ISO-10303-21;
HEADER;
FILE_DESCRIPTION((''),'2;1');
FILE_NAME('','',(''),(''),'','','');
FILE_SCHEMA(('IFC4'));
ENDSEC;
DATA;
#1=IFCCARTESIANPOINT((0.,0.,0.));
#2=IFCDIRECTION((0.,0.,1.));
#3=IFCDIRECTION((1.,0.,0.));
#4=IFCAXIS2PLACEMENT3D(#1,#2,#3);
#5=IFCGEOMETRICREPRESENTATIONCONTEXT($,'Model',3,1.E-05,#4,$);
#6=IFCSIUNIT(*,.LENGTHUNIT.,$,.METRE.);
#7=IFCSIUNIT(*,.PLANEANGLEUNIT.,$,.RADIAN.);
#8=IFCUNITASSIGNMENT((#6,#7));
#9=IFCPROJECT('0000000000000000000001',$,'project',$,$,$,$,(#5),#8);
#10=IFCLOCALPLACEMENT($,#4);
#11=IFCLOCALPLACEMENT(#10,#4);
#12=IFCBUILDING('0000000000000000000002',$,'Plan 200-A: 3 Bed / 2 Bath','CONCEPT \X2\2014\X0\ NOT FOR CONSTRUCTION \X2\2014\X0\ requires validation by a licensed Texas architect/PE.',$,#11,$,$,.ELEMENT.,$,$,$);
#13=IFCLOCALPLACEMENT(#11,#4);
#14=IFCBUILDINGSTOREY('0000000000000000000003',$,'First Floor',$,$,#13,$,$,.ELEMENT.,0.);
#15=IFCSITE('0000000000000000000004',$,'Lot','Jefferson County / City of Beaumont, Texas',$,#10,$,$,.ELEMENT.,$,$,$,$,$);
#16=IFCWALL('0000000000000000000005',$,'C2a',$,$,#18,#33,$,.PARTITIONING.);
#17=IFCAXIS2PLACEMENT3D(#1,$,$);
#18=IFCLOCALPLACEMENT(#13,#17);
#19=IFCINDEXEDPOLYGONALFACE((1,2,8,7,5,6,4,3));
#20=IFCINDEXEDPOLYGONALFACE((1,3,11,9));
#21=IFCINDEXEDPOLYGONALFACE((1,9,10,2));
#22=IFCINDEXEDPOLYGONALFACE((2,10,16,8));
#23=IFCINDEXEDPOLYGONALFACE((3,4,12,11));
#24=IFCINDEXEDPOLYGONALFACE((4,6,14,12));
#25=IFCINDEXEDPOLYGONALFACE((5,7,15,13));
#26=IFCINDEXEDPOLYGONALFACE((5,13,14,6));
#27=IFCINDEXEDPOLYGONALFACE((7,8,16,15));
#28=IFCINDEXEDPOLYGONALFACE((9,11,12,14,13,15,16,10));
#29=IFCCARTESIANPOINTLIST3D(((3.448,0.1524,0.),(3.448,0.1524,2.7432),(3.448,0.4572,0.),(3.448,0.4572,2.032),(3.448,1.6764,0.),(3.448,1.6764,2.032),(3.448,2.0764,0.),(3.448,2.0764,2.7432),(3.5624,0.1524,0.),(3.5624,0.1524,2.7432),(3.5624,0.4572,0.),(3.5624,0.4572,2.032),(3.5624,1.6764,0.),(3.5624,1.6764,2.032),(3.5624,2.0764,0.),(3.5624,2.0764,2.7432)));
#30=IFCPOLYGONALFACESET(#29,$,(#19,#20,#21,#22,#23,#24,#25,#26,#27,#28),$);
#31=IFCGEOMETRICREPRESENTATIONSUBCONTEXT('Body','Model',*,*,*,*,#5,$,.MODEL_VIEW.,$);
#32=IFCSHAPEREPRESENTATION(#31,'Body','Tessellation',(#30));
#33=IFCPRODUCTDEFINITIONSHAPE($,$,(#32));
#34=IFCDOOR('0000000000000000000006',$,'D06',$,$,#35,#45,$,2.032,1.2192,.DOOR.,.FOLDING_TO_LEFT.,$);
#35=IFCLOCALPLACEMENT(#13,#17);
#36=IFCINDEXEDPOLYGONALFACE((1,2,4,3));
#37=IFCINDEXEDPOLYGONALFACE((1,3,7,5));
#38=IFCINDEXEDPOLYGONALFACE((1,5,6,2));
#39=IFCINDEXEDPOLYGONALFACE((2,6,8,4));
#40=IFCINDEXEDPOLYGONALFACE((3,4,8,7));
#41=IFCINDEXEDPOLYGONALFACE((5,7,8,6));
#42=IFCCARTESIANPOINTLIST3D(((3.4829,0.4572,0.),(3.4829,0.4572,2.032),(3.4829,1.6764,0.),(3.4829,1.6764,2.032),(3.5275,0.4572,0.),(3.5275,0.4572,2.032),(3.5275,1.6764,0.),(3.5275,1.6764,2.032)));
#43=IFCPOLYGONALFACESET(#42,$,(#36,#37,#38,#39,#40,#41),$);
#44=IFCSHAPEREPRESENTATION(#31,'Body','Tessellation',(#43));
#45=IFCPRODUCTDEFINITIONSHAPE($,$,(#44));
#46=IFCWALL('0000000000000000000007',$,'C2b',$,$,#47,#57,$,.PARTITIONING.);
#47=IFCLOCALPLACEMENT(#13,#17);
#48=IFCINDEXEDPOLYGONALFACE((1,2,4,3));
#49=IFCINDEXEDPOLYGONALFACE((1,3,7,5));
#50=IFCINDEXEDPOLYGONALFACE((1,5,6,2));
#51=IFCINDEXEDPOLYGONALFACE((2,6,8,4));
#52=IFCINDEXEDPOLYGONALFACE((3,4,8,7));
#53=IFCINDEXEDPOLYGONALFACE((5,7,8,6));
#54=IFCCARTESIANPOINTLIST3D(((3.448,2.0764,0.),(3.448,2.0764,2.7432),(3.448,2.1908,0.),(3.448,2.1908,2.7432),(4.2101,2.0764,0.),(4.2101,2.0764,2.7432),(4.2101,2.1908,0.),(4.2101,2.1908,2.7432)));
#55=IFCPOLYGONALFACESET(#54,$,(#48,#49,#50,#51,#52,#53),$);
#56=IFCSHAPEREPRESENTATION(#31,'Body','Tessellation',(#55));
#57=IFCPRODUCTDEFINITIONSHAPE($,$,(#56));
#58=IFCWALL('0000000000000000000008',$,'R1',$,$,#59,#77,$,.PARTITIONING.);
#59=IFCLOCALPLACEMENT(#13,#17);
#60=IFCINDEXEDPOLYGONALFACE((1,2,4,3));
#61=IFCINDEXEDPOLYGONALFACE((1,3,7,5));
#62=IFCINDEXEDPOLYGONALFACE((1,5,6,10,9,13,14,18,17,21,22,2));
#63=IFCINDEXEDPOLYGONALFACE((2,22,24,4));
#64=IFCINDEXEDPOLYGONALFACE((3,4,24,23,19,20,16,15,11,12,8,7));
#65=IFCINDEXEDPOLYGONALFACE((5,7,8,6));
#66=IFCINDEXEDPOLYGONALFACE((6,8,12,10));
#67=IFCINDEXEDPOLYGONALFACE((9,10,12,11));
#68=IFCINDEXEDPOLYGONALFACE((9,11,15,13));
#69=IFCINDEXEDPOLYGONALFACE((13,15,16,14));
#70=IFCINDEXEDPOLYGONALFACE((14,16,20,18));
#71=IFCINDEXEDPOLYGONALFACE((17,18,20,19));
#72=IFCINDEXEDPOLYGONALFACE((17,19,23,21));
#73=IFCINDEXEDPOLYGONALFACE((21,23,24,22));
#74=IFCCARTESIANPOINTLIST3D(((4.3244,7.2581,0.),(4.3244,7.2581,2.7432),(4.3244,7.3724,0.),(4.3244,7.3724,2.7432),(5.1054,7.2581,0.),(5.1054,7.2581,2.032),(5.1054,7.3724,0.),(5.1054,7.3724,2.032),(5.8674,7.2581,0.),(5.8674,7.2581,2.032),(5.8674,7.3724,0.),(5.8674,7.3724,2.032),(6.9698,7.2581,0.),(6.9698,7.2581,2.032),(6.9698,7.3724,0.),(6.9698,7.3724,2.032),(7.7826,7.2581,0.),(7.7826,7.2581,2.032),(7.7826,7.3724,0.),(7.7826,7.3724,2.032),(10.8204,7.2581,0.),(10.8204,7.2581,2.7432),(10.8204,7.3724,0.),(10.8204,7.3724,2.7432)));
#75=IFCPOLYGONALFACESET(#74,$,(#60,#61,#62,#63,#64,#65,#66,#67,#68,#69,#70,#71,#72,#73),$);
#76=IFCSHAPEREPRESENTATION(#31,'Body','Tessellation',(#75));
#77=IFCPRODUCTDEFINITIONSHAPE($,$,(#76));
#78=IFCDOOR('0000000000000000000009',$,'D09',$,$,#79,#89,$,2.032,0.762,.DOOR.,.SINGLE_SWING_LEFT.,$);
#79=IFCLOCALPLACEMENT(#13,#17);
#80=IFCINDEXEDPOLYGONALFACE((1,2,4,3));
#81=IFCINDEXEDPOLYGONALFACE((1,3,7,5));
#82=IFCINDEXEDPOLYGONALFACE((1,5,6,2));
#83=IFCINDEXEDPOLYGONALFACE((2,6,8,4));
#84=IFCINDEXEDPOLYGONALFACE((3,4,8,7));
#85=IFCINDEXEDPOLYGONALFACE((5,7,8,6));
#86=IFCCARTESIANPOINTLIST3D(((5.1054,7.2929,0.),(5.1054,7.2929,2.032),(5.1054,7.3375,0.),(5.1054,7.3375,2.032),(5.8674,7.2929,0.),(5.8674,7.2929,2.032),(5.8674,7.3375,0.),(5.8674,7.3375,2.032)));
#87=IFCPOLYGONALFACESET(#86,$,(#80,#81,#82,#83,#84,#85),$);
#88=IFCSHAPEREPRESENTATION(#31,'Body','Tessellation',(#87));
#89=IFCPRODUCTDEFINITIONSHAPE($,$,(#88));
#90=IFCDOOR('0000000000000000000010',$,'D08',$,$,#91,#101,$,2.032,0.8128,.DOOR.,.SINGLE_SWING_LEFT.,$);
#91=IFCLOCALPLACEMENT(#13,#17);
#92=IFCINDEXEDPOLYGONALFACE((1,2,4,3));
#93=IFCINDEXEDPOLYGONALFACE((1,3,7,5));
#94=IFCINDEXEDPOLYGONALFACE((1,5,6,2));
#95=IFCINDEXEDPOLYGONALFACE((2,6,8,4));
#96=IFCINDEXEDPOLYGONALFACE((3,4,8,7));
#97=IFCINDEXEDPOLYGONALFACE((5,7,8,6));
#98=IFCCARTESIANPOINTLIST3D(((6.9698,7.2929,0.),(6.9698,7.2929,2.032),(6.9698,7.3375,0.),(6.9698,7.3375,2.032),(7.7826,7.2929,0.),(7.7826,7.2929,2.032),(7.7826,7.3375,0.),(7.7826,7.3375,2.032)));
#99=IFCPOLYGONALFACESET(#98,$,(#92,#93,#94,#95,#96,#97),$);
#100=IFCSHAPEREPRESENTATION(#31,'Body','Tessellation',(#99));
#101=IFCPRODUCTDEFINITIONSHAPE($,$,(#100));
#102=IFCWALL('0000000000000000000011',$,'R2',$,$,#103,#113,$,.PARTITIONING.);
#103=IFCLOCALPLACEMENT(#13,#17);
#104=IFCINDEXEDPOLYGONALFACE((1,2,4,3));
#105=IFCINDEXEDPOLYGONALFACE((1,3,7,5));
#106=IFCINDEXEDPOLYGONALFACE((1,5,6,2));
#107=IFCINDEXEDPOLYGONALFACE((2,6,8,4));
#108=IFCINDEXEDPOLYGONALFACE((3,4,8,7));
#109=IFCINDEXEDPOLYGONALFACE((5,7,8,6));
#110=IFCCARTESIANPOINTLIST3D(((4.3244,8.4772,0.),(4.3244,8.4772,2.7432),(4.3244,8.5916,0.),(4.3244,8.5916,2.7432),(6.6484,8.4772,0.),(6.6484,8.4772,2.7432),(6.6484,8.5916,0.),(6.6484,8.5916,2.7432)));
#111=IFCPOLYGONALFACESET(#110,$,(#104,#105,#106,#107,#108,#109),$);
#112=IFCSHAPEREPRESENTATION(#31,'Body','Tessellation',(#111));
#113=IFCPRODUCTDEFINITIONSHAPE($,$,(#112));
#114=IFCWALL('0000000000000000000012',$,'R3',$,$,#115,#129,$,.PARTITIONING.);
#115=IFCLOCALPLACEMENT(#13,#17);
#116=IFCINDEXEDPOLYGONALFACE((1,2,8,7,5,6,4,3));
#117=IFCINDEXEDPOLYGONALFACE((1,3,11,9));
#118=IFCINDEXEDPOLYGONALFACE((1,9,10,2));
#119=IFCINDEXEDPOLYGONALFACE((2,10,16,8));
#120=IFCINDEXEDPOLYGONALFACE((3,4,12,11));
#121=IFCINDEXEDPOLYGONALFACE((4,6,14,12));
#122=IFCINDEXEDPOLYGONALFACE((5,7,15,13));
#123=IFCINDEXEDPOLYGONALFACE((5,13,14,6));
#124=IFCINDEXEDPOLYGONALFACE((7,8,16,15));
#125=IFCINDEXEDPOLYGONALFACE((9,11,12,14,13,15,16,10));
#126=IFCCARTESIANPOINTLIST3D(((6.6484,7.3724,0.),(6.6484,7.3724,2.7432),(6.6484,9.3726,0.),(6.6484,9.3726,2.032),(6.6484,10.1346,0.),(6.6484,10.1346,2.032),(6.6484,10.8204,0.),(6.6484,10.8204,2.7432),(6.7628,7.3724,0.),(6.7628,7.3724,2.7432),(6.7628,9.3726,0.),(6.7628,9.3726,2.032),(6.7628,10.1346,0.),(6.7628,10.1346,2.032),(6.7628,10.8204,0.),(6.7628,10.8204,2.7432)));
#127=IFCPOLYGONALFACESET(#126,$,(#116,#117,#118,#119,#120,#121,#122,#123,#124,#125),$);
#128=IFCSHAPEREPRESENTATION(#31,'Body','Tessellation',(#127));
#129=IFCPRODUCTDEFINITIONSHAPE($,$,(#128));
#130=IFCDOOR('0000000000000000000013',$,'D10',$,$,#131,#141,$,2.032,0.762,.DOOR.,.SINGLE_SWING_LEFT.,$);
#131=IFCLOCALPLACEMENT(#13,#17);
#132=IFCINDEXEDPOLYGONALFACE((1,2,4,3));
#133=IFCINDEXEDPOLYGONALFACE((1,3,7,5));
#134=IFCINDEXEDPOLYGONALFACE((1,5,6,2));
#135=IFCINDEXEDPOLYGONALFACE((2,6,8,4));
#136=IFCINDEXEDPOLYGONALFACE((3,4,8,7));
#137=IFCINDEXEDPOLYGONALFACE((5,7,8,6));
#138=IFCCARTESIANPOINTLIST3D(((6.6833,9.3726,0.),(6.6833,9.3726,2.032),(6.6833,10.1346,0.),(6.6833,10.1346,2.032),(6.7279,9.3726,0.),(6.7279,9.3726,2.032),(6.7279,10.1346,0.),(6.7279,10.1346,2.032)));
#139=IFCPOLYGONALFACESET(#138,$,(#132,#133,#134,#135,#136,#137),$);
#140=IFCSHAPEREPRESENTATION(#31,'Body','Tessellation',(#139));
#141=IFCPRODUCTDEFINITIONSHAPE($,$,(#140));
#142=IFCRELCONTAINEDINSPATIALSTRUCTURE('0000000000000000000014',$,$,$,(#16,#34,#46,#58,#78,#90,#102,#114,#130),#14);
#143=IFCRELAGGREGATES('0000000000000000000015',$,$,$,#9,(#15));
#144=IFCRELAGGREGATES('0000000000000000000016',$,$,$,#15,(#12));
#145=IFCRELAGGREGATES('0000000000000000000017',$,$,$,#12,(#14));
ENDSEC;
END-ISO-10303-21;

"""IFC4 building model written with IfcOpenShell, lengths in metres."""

from ifc_helpers import new_model, si_unit, frame, frame_2d, origin_with_axes, place, context, subcontext, project, spatial, rectangle, extrude, element, fill, save


model = new_model("IFC4")

# Units and contexts
model_context = context("Model", 3, precision=1e-05, world=origin_with_axes())
body_context = subcontext(model_context, "Body", "Model", "MODEL_VIEW")
ifc_project = project(units=[si_unit("LENGTHUNIT", "METRE"), si_unit("PLANEANGLEUNIT", "RADIAN")], contexts=[model_context])

# Site, building, storey
site_placement = place(None, origin_with_axes())
site = spatial("IfcSite", under=ifc_project, at=site_placement, Name="Lot", Description="Jefferson County / City of Beaumont, Texas", CompositionType="ELEMENT")
building_placement = place(site_placement, origin_with_axes())
building = spatial("IfcBuilding", under=site, at=building_placement, Name="Plan 200-A: 3 Bed / 2 Bath", Description="CONCEPT — NOT FOR CONSTRUCTION — requires validation by a licensed Texas architect/PE.", CompositionType="ELEMENT")
storey_placement = place(building_placement, origin_with_axes())
storey = spatial("IfcBuildingStorey", under=building, at=storey_placement, Name="First Floor", CompositionType="ELEMENT", Elevation=0.0)

# Wall, opening, door
wall_1_placement = place(storey_placement, frame((3.5052, 0.1524, 0.0), z_axis=(0.0, 0.0, 1.0), x_axis=(0.0, 1.0, 0.0)))
wall_1 = element("IfcWall", 1, at=wall_1_placement, inside=storey, Name="C2a", PredefinedType="PARTITIONING", context=body_context, shape_type="SweptSolid", body=[
    extrude(rectangle(XDim=1.9241, YDim=0.1143, at=frame_2d((0.962, 0.0), x_axis=(1.0, 0.0))), origin_with_axes(), (0.0, 0.0, 1.0), 2.7432),
])
opening_1_placement = place(wall_1_placement, frame((0.3048, 0.0, 0.0), z_axis=(0.0, 0.0, 1.0), x_axis=(1.0, 0.0, 0.0)))
opening_1 = element("IfcOpeningElement", 2, at=opening_1_placement, cuts=wall_1, PredefinedType="OPENING", context=body_context, shape_type="SweptSolid", body=[
    extrude(rectangle(XDim=1.2192, YDim=0.1448, at=frame_2d((0.6096, 0.0), x_axis=(1.0, 0.0))), origin_with_axes(), (0.0, 0.0, 1.0), 2.032),
])
door_1_placement = place(opening_1_placement, origin_with_axes())
door_1 = element("IfcDoor", 3, at=door_1_placement, inside=storey, Name="D06", OperationType="FOLDING_TO_LEFT", OverallHeight=2.032, OverallWidth=1.2192, PredefinedType="DOOR", context=body_context, shape_type="SweptSolid", body=[
    extrude(rectangle(XDim=1.2192, YDim=0.0445, at=frame_2d((0.6096, 0.0), x_axis=(1.0, 0.0))), origin_with_axes(), (0.0, 0.0, 1.0), 2.032),
])
fill(opening_1, door_1)

# Wall
wall_2_placement = place(storey_placement, frame((3.4481, 2.1336, 0.0), z_axis=(0.0, 0.0, 1.0), x_axis=(1.0, 0.0, 0.0)))
element("IfcWall", 4, at=wall_2_placement, inside=storey, Name="C2b", PredefinedType="PARTITIONING", context=body_context, shape_type="SweptSolid", body=[
    extrude(rectangle(XDim=0.762, YDim=0.1143, at=frame_2d((0.381, 0.0), x_axis=(1.0, 0.0))), origin_with_axes(), (0.0, 0.0, 1.0), 2.7432),
])

# Wall, openings, doors
wall_3_placement = place(storey_placement, frame((4.3243, 7.3152, 0.0), z_axis=(0.0, 0.0, 1.0), x_axis=(1.0, 0.0, 0.0)))
wall_3 = element("IfcWall", 5, at=wall_3_placement, inside=storey, Name="R1", PredefinedType="PARTITIONING", context=body_context, shape_type="SweptSolid", body=[
    extrude(rectangle(XDim=6.4961, YDim=0.1143, at=frame_2d((3.248, 0.0), x_axis=(1.0, 0.0))), origin_with_axes(), (0.0, 0.0, 1.0), 2.7432),
])
opening_2_placement = place(wall_3_placement, frame((0.7811, 0.0, 0.0), z_axis=(0.0, 0.0, 1.0), x_axis=(1.0, 0.0, 0.0)))
opening_2 = element("IfcOpeningElement", 6, at=opening_2_placement, cuts=wall_3, PredefinedType="OPENING", context=body_context, shape_type="SweptSolid", body=[
    extrude(rectangle(XDim=0.762, YDim=0.1448, at=frame_2d((0.381, 0.0), x_axis=(1.0, 0.0))), origin_with_axes(), (0.0, 0.0, 1.0), 2.032),
])
opening_3_placement = place(wall_3_placement, frame((2.6454, 0.0, 0.0), z_axis=(0.0, 0.0, 1.0), x_axis=(1.0, 0.0, 0.0)))
opening_3 = element("IfcOpeningElement", 7, at=opening_3_placement, cuts=wall_3, PredefinedType="OPENING", context=body_context, shape_type="SweptSolid", body=[
    extrude(rectangle(XDim=0.8128, YDim=0.1448, at=frame_2d((0.4064, 0.0), x_axis=(1.0, 0.0))), origin_with_axes(), (0.0, 0.0, 1.0), 2.032),
])
door_2_placement = place(opening_2_placement, origin_with_axes())
door_2 = element("IfcDoor", 8, at=door_2_placement, inside=storey, Name="D09", OperationType="SINGLE_SWING_LEFT", OverallHeight=2.032, OverallWidth=0.762, PredefinedType="DOOR", context=body_context, shape_type="SweptSolid", body=[
    extrude(rectangle(XDim=0.762, YDim=0.0445, at=frame_2d((0.381, 0.0), x_axis=(1.0, 0.0))), origin_with_axes(), (0.0, 0.0, 1.0), 2.032),
])
fill(opening_2, door_2)
door_3_placement = place(opening_3_placement, origin_with_axes())
door_3 = element("IfcDoor", 9, at=door_3_placement, inside=storey, Name="D08", OperationType="SINGLE_SWING_LEFT", OverallHeight=2.032, OverallWidth=0.8128, PredefinedType="DOOR", context=body_context, shape_type="SweptSolid", body=[
    extrude(rectangle(XDim=0.8128, YDim=0.0445, at=frame_2d((0.4064, 0.0), x_axis=(1.0, 0.0))), origin_with_axes(), (0.0, 0.0, 1.0), 2.032),
])
fill(opening_3, door_3)

# Wall
wall_4_placement = place(storey_placement, frame((4.3243, 8.5344, 0.0), z_axis=(0.0, 0.0, 1.0), x_axis=(1.0, 0.0, 0.0)))
element("IfcWall", 10, at=wall_4_placement, inside=storey, Name="R2", PredefinedType="PARTITIONING", context=body_context, shape_type="SweptSolid", body=[
    extrude(rectangle(XDim=2.3241, YDim=0.1143, at=frame_2d((1.1621, 0.0), x_axis=(1.0, 0.0))), origin_with_axes(), (0.0, 0.0, 1.0), 2.7432),
])

# Wall, opening, door
wall_5_placement = place(storey_placement, frame((6.7056, 7.3723, 0.0), z_axis=(0.0, 0.0, 1.0), x_axis=(0.0, 1.0, 0.0)))
wall_5 = element("IfcWall", 11, at=wall_5_placement, inside=storey, Name="R3", PredefinedType="PARTITIONING", context=body_context, shape_type="SweptSolid", body=[
    extrude(rectangle(XDim=3.4481, YDim=0.1143, at=frame_2d((1.724, 0.0), x_axis=(1.0, 0.0))), origin_with_axes(), (0.0, 0.0, 1.0), 2.7432),
])
opening_4_placement = place(wall_5_placement, frame((2.0003, 0.0, 0.0), z_axis=(0.0, 0.0, 1.0), x_axis=(1.0, 0.0, 0.0)))
opening_4 = element("IfcOpeningElement", 12, at=opening_4_placement, cuts=wall_5, PredefinedType="OPENING", context=body_context, shape_type="SweptSolid", body=[
    extrude(rectangle(XDim=0.762, YDim=0.1448, at=frame_2d((0.381, 0.0), x_axis=(1.0, 0.0))), origin_with_axes(), (0.0, 0.0, 1.0), 2.032),
])
door_4_placement = place(opening_4_placement, origin_with_axes())
door_4 = element("IfcDoor", 13, at=door_4_placement, inside=storey, Name="D10", OperationType="SINGLE_SWING_LEFT", OverallHeight=2.032, OverallWidth=0.762, PredefinedType="DOOR", context=body_context, shape_type="SweptSolid", body=[
    extrude(rectangle(XDim=0.762, YDim=0.0445, at=frame_2d((0.381, 0.0), x_axis=(1.0, 0.0))), origin_with_axes(), (0.0, 0.0, 1.0), 2.032),
])
fill(opening_4, door_4)

save(model, "model.ifc")
